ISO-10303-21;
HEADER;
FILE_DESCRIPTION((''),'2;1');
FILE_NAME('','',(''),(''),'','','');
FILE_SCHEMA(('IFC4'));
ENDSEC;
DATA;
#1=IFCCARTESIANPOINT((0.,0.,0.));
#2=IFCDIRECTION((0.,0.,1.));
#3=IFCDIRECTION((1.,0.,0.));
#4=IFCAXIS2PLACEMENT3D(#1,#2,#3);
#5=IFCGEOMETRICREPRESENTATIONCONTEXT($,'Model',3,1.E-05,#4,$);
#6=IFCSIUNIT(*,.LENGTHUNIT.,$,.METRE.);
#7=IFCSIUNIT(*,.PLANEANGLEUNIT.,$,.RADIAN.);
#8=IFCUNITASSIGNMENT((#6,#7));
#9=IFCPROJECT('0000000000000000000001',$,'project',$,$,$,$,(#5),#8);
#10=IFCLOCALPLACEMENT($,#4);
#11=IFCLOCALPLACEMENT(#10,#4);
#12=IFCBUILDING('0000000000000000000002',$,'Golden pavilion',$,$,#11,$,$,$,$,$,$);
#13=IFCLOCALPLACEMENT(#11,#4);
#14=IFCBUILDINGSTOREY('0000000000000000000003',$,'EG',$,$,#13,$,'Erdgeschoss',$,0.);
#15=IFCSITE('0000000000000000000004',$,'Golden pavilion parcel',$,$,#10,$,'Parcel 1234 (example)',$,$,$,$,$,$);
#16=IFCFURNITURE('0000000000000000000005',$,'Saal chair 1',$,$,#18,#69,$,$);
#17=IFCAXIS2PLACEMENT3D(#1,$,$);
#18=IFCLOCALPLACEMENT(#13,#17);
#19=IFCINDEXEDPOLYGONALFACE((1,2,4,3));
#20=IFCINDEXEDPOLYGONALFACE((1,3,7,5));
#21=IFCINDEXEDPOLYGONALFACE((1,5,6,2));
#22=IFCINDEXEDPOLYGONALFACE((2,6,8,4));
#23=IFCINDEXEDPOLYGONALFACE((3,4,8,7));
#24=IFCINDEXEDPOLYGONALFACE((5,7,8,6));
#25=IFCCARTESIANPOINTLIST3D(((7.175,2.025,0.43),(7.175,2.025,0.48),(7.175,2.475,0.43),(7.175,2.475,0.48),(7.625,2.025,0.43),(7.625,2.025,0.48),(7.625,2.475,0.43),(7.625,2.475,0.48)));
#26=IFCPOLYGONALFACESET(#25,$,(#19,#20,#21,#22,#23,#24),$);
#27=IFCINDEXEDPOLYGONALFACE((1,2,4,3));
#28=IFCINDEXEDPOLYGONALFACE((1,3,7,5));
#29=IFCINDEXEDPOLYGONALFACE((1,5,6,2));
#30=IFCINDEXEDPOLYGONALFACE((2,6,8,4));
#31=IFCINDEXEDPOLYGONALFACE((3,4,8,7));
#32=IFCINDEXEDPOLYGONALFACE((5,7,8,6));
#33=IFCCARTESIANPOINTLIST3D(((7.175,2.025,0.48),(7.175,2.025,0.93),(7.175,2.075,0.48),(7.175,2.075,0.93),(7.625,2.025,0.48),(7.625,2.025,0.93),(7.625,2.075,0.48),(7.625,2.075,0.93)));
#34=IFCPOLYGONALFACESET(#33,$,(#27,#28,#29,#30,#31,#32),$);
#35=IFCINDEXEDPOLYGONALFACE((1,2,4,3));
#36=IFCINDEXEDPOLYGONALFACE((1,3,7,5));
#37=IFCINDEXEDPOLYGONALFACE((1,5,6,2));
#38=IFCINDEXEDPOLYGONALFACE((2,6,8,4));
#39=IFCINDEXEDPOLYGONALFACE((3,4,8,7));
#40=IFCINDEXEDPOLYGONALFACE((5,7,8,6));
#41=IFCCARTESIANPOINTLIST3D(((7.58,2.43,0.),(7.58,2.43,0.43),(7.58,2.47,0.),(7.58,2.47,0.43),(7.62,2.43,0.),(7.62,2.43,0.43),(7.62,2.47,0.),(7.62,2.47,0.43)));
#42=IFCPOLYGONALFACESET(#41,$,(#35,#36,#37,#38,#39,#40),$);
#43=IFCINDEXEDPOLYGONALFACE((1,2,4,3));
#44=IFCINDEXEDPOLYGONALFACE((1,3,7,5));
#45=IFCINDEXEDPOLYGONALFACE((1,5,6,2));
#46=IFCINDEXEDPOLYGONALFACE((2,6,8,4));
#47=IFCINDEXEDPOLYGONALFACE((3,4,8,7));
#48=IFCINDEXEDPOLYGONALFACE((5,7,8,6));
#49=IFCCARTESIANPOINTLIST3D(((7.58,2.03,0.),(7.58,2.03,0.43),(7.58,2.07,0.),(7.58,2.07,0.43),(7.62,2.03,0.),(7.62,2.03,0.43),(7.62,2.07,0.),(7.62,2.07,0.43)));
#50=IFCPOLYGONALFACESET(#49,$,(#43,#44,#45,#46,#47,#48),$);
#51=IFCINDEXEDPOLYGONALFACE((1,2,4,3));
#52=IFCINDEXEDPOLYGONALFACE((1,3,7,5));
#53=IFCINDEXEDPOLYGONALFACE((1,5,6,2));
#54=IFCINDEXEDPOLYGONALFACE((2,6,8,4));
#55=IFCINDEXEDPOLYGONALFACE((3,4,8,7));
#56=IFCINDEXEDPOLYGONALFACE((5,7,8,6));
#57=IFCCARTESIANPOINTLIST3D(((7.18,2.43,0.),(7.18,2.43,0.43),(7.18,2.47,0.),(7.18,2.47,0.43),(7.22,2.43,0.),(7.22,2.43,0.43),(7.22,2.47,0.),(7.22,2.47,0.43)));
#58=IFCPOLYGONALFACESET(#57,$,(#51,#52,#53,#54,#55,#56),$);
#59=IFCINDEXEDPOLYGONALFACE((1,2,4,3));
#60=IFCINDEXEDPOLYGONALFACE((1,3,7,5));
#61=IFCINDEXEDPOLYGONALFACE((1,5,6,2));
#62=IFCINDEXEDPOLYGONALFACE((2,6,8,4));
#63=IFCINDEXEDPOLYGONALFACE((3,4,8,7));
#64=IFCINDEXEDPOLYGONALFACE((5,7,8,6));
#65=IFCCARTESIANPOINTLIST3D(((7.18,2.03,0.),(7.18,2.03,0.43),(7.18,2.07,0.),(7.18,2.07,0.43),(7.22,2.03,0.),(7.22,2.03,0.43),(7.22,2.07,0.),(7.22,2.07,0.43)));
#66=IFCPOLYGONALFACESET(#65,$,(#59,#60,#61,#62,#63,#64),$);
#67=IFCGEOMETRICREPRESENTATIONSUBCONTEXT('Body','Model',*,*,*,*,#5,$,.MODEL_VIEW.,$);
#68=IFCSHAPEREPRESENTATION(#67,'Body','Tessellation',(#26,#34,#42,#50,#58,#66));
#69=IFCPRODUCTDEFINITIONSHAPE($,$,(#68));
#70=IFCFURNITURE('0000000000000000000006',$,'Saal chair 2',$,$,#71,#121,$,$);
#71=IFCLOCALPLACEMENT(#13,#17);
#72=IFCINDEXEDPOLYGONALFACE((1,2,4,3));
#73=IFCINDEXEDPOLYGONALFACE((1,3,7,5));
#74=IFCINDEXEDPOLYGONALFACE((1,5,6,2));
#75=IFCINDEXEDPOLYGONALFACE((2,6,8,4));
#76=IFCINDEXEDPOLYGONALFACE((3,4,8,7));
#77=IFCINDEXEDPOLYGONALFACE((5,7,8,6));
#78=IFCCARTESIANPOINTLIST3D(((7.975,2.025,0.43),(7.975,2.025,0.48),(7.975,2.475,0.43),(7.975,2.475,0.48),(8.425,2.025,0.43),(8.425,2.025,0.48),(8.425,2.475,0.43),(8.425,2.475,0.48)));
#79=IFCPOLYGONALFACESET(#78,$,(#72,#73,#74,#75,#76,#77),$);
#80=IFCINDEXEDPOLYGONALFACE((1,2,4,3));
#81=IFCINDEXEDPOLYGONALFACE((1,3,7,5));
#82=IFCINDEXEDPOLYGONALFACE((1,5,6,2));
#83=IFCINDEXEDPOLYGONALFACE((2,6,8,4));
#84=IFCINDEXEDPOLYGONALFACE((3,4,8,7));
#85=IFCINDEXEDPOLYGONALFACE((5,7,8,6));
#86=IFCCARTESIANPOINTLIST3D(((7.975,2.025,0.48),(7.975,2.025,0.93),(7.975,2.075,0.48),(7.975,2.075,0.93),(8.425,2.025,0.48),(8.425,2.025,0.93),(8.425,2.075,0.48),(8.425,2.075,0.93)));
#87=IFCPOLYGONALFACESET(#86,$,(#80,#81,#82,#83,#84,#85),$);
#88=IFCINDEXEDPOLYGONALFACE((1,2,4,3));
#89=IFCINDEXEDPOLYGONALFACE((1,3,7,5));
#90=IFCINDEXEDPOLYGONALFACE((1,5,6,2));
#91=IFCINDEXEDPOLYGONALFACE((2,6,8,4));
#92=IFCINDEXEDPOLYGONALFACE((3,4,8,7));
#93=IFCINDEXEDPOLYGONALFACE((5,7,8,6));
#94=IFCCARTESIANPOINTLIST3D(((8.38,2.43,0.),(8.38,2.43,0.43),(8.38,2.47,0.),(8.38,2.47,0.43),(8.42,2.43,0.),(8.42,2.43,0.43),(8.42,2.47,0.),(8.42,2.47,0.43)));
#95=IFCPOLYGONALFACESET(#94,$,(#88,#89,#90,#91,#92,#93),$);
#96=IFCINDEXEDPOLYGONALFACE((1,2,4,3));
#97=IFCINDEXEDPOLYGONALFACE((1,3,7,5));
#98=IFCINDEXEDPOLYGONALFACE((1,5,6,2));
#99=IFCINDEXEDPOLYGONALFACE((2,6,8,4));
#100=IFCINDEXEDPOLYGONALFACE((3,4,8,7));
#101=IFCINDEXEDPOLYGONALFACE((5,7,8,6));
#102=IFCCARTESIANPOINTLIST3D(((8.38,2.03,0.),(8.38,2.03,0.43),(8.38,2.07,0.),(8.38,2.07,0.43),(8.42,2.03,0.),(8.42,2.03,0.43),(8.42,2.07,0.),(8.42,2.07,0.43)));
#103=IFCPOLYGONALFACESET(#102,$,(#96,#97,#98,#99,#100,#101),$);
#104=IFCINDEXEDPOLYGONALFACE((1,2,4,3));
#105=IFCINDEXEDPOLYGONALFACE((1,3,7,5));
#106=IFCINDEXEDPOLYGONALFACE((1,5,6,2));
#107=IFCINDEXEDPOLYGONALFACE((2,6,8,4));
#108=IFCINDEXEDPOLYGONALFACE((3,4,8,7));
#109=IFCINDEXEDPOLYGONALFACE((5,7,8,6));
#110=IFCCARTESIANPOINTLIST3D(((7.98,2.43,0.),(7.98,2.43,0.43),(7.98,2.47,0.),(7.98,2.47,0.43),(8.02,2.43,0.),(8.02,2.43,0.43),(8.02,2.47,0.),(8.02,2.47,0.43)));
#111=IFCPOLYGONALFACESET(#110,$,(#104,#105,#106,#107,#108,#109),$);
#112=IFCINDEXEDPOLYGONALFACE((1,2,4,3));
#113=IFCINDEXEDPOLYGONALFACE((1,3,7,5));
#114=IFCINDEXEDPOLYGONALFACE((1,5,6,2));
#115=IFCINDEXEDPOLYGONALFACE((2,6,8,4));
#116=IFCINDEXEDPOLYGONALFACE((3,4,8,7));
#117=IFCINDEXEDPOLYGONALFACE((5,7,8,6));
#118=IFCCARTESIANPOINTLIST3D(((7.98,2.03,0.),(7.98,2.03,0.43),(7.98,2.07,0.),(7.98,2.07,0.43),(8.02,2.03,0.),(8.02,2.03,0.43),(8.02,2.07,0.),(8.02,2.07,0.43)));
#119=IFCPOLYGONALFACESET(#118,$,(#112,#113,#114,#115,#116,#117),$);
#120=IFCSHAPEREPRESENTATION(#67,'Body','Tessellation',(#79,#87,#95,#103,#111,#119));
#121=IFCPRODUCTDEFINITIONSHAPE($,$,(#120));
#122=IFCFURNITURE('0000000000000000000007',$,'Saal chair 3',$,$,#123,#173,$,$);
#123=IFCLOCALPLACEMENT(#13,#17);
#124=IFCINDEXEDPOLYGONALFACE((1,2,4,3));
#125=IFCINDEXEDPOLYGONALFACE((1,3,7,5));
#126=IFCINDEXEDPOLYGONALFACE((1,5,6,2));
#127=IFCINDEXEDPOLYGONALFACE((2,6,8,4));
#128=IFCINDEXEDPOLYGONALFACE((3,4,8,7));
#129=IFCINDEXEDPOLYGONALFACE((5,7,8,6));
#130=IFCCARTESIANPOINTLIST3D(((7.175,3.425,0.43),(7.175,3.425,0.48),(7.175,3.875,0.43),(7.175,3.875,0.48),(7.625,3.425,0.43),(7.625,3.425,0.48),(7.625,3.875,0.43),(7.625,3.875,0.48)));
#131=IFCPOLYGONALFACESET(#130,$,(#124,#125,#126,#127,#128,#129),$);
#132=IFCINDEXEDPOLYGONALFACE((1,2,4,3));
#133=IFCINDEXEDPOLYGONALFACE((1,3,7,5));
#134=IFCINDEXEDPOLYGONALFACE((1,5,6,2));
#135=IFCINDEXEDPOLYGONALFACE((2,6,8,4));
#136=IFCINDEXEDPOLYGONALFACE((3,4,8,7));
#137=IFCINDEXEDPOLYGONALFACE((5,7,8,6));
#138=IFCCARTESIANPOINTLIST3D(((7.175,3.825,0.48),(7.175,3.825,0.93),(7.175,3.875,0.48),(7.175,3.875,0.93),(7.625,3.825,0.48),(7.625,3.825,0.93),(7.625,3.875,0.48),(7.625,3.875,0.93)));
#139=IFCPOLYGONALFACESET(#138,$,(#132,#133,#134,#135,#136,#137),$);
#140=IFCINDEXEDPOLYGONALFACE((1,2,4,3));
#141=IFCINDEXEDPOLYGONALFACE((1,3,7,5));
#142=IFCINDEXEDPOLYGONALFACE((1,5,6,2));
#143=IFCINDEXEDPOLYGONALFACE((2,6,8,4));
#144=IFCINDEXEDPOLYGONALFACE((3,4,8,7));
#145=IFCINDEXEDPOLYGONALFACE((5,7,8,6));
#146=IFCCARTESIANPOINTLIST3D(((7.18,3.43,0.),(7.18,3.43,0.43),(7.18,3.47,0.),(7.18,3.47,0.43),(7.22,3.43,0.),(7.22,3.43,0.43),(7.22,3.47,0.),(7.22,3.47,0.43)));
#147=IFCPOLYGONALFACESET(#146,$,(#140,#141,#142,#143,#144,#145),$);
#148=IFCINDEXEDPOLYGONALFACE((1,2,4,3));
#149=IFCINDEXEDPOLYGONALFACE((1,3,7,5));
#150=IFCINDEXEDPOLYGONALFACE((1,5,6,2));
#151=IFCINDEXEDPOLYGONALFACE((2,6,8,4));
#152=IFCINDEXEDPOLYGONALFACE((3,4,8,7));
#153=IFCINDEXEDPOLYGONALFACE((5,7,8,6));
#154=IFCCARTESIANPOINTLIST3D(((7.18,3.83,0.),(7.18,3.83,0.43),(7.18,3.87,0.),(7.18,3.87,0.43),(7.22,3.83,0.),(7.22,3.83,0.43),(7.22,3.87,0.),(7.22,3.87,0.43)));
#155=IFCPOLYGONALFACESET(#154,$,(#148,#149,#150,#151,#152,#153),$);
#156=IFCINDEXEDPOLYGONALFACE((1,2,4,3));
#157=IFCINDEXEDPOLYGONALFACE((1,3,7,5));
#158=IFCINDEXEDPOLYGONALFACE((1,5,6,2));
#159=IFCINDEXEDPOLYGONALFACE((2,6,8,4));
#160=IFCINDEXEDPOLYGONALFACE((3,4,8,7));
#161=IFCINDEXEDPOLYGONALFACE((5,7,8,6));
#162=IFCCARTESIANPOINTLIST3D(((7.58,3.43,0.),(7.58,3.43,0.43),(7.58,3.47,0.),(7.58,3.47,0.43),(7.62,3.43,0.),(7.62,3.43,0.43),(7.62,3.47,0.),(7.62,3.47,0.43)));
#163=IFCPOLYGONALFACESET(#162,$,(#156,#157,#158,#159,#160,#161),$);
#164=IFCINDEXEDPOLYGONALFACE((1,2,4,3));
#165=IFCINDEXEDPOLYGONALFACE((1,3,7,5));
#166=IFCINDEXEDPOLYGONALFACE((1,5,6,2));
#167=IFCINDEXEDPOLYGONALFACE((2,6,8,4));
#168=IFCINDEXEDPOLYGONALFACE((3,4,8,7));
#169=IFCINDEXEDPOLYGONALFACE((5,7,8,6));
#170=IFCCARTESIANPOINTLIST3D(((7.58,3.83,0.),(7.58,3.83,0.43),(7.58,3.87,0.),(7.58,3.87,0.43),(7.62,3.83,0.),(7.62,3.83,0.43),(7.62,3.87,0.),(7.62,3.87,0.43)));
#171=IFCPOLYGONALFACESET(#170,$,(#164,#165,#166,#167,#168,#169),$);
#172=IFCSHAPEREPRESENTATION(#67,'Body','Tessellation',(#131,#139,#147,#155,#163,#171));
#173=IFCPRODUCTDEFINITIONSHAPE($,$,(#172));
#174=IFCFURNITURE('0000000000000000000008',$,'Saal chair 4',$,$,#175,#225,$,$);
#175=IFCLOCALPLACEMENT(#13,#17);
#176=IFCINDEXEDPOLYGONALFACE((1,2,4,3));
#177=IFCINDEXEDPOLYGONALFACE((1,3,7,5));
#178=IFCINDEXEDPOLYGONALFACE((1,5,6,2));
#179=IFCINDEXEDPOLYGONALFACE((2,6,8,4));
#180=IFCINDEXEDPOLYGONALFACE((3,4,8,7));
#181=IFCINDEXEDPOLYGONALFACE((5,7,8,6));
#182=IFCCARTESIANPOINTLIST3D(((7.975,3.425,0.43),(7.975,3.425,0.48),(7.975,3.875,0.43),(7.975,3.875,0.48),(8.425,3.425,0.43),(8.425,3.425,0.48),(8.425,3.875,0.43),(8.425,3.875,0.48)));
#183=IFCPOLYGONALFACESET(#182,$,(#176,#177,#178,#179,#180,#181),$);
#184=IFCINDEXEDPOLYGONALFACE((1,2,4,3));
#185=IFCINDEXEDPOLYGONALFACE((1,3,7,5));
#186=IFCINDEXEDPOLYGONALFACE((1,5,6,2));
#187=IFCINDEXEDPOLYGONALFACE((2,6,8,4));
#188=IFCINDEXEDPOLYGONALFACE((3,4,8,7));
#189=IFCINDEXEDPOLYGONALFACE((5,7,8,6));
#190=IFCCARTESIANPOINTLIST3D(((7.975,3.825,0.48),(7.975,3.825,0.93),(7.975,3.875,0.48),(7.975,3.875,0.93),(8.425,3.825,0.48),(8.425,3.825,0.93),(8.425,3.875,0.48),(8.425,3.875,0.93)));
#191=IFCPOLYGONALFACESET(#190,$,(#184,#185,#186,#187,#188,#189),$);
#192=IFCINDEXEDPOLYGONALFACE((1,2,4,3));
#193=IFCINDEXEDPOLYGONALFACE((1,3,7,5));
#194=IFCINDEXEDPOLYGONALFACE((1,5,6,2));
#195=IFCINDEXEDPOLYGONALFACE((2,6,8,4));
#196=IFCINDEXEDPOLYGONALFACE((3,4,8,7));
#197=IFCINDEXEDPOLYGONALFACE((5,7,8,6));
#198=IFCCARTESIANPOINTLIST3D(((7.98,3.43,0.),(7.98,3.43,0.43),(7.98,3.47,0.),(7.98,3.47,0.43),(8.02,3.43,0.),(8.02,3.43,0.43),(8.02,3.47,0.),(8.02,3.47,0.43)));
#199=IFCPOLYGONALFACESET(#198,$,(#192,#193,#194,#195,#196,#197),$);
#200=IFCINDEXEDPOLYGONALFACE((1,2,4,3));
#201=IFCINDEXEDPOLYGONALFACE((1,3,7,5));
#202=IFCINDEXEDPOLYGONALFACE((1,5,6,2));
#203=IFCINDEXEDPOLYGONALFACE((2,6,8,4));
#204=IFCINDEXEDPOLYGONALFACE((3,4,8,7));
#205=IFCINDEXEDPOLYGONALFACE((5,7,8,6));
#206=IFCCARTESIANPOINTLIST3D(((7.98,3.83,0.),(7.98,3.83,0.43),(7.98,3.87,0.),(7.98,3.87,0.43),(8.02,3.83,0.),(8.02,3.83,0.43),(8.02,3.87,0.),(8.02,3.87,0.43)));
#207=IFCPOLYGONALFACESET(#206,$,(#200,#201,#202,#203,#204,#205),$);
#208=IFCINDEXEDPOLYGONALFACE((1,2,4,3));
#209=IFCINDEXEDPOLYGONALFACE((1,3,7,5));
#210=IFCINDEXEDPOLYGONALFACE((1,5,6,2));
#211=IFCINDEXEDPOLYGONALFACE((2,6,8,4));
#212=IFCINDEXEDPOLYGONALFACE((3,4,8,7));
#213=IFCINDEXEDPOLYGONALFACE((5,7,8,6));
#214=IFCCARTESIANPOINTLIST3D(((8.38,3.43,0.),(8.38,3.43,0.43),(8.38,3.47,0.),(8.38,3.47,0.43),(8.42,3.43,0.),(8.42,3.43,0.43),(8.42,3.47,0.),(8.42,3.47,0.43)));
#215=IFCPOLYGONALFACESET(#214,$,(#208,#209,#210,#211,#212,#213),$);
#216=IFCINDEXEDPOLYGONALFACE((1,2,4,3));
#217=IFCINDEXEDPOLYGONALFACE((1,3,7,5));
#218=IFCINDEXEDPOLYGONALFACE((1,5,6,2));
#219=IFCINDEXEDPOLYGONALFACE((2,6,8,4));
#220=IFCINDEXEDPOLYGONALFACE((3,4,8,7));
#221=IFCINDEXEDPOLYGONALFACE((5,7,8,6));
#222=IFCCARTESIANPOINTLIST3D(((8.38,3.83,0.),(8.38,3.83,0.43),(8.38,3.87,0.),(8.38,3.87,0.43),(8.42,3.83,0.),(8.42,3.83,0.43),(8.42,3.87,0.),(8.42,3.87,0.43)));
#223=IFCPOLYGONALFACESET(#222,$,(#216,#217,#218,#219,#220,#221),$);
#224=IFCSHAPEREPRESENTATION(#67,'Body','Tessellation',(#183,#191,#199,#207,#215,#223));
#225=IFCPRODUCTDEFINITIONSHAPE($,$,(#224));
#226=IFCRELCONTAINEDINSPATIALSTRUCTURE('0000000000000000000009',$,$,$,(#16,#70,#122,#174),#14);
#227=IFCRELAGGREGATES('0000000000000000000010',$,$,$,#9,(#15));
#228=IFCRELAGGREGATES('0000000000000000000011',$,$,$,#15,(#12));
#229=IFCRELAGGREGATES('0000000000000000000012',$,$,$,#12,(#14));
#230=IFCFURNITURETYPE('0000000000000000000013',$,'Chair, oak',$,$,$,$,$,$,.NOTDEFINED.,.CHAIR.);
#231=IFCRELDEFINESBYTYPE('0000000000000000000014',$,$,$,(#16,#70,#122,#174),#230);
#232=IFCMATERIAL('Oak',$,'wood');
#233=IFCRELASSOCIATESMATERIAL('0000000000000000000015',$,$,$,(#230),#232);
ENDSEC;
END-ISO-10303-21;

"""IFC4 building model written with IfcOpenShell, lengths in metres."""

from ifc_helpers import new_model, si_unit, frame, origin_with_axes, place, context, subcontext, project, spatial, line, indexed_curve, outline, extrude, source, transform, mapped, material, type_object, type_shapes, element, save


model = new_model("IFC4")

# Units and contexts
model_context = context("Model", 3, precision=1e-05, world=origin_with_axes())
body_context = subcontext(model_context, "Body", "Model", "MODEL_VIEW")
ifc_project = project(units=[si_unit("LENGTHUNIT", "METRE"), si_unit("PLANEANGLEUNIT", "RADIAN")], contexts=[model_context])

# Site, building, storey
site_placement = place(None, origin_with_axes())
site = spatial("IfcSite", under=ifc_project, at=site_placement, Name="Golden pavilion parcel", LongName="Parcel 1234 (example)")
building_placement = place(site_placement, origin_with_axes())
building = spatial("IfcBuilding", under=site, at=building_placement, Name="Golden pavilion")
storey_placement = place(building_placement, origin_with_axes())
storey = spatial("IfcBuildingStorey", under=building, at=storey_placement, Name="EG", LongName="Erdgeschoss", Elevation=0.0)

# Shared definitions
ifc_material_1 = material(Name="Oak", Category="wood")

# Furniture
furniture_type_1 = type_object("IfcFurnitureType", Name="Chair, oak", AssemblyPlace="NOTDEFINED", PredefinedType="CHAIR", material=ifc_material_1)
shared_shape_1 = source(origin_with_axes(), body_context, "Body", "SweptSolid", [
    extrude(outline(indexed_curve([(-0.225, -0.225), (0.225, -0.225), (0.225, 0.225), (-0.225, 0.225)], segments=[line(1, 2, 3, 4, 1)])), frame((0.0, 0.0, 0.43), z_axis=(0.0, 0.0, 1.0), x_axis=(1.0, 0.0, 0.0)), (0.0, 0.0, 1.0), 0.05),
    extrude(outline(indexed_curve([(-0.225, 0.175), (0.225, 0.175), (0.225, 0.225), (-0.225, 0.225)], segments=[line(1, 2, 3, 4, 1)])), frame((0.0, 0.0, 0.48), z_axis=(0.0, 0.0, 1.0), x_axis=(1.0, 0.0, 0.0)), (0.0, 0.0, 1.0), 0.45),
    extrude(outline(indexed_curve([(-0.22, -0.22), (-0.18, -0.22), (-0.18, -0.18), (-0.22, -0.18)], segments=[line(1, 2, 3, 4, 1)])), origin_with_axes(), (0.0, 0.0, 1.0), 0.43),
    extrude(outline(indexed_curve([(-0.22, 0.18), (-0.18, 0.18), (-0.18, 0.22), (-0.22, 0.22)], segments=[line(1, 2, 3, 4, 1)])), origin_with_axes(), (0.0, 0.0, 1.0), 0.43),
    extrude(outline(indexed_curve([(0.18, -0.22), (0.22, -0.22), (0.22, -0.18), (0.18, -0.18)], segments=[line(1, 2, 3, 4, 1)])), origin_with_axes(), (0.0, 0.0, 1.0), 0.43),
    extrude(outline(indexed_curve([(0.18, 0.18), (0.22, 0.18), (0.22, 0.22), (0.18, 0.22)], segments=[line(1, 2, 3, 4, 1)])), origin_with_axes(), (0.0, 0.0, 1.0), 0.43),
])
type_shapes(furniture_type_1, [shared_shape_1])
for number, where, z_axis, x_axis, name in (
    (1, (7.4, 2.25, 0.0), (0.0, 0.0, 1.0), (-1.0, 0.0, 0.0), "Saal chair 1"),
    (2, (8.2, 2.25, 0.0), (0.0, 0.0, 1.0), (-1.0, 0.0, 0.0), "Saal chair 2"),
    (3, (7.4, 3.65, 0.0), (0.0, 0.0, 1.0), (1.0, 0.0, 0.0), "Saal chair 3"),
    (4, (8.2, 3.65, 0.0), (0.0, 0.0, 1.0), (1.0, 0.0, 0.0), "Saal chair 4"),
):
    element("IfcFurniture", number, at=place(storey_placement, frame(where, z_axis=z_axis, x_axis=x_axis)), inside=storey, type_object=furniture_type_1, Name=name, context=body_context, shape_type="MappedRepresentation", body=[
        mapped(shared_shape_1, transform((0.0, 0.0, 0.0), x_axis=(1.0, 0.0, 0.0), y_axis=(0.0, 1.0, 0.0), z_axis=(0.0, 0.0, 1.0), scale=1.0)),
    ])

save(model, "model.ifc")
